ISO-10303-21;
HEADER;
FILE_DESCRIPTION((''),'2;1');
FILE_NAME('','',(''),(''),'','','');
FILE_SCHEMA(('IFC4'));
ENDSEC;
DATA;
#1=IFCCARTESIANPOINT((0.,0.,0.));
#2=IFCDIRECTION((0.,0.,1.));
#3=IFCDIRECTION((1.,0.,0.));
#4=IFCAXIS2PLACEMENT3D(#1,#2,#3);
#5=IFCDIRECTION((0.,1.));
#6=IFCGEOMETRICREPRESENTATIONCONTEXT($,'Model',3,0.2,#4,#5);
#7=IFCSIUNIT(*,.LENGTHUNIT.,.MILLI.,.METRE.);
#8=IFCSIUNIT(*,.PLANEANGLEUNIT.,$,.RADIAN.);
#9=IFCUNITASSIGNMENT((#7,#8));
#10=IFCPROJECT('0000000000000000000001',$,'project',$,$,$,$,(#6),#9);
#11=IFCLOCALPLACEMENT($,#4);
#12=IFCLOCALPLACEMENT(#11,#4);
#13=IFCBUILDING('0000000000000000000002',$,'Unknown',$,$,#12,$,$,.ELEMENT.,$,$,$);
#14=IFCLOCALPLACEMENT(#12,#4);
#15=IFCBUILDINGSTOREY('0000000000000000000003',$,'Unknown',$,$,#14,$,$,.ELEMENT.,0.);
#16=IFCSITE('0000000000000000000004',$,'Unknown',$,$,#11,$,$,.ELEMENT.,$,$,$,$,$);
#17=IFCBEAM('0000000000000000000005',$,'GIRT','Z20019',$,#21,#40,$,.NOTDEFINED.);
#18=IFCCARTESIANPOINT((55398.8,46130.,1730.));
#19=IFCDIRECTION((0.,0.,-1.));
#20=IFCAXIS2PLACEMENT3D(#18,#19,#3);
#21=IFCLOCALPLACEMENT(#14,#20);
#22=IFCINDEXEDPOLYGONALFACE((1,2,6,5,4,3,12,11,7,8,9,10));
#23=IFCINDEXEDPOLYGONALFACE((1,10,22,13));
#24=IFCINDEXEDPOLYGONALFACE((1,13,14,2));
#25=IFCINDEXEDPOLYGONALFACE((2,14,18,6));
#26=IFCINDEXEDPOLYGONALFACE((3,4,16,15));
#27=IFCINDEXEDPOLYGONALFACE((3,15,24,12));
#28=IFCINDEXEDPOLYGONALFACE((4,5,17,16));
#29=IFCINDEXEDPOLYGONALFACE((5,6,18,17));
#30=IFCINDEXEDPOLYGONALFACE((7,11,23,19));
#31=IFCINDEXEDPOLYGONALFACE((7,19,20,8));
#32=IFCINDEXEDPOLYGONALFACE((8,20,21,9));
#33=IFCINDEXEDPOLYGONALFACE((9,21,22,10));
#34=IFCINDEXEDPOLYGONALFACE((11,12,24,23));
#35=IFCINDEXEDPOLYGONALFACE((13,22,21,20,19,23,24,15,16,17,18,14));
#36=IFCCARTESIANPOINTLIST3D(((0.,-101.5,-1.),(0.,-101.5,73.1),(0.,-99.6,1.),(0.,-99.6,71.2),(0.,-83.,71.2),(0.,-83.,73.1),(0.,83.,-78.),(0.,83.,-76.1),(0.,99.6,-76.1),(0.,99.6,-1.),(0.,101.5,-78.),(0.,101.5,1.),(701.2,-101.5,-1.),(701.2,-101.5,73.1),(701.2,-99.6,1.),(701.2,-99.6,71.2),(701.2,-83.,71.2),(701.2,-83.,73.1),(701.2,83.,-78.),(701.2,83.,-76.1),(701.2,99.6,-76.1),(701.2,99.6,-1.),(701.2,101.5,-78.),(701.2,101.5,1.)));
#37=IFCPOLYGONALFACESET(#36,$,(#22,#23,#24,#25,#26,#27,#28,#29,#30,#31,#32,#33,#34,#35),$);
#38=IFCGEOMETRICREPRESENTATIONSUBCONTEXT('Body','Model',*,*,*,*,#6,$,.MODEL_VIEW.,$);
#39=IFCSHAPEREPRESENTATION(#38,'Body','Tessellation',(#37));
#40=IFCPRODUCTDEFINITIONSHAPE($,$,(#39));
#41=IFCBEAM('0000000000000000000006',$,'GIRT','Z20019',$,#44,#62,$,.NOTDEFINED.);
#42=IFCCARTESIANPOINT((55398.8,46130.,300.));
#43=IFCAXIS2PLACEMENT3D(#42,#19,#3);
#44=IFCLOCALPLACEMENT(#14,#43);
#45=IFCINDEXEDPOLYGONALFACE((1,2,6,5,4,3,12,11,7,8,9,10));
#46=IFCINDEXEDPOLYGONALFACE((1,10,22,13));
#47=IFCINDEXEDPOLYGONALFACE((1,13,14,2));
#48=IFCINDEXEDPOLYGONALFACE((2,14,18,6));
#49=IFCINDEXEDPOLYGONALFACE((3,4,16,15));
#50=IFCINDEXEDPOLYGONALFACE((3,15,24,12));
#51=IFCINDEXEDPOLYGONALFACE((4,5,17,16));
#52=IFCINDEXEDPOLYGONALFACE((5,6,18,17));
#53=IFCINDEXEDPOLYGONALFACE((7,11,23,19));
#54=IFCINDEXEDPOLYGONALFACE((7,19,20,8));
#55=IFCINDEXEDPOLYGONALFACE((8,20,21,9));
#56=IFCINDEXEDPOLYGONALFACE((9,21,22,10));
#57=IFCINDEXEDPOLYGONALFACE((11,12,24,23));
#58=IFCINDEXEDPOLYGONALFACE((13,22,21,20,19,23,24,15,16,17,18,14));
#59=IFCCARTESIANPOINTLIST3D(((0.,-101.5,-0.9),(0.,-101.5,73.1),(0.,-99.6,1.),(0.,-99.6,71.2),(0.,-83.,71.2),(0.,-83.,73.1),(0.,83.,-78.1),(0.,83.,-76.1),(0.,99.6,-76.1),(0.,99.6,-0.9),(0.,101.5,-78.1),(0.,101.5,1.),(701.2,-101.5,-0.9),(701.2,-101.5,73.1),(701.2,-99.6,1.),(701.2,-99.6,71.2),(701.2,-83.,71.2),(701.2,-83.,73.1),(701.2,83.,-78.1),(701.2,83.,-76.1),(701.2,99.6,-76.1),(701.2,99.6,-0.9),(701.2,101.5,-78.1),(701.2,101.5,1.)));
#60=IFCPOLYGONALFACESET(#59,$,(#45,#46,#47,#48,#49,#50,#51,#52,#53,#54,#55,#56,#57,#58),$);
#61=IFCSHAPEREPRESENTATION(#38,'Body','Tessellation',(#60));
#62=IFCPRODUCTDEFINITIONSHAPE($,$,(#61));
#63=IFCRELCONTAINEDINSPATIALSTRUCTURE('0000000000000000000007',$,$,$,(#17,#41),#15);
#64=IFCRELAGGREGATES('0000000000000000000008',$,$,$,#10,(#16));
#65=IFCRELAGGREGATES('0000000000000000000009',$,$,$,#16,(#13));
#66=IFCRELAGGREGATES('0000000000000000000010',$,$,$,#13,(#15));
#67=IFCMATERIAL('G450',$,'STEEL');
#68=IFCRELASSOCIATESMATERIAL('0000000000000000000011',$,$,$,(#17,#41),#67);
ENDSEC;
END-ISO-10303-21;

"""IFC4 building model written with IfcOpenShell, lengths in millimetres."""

from ifc_helpers import new_model, si_unit, direction, frame, origin_with_axes, place, context, subcontext, project, spatial, line, indexed_curve, outline, extrude, material, element, save


model = new_model("IFC4")

# Units and contexts
model_context = context("Model", 3, precision=0.2, world=origin_with_axes(), true_north=direction((0.0, 1.0)))
body_context = subcontext(model_context, "Body", "Model", "MODEL_VIEW")
ifc_project = project(units=[si_unit("LENGTHUNIT", "METRE", prefix="MILLI"), si_unit("PLANEANGLEUNIT", "RADIAN")], contexts=[model_context])

# Site, building, storey
site_placement = place(None, origin_with_axes())
site = spatial("IfcSite", under=ifc_project, at=site_placement, Name="Unknown", CompositionType="ELEMENT")
building_placement = place(site_placement, origin_with_axes())
building = spatial("IfcBuilding", under=site, at=building_placement, Name="Unknown", CompositionType="ELEMENT")
storey_placement = place(building_placement, origin_with_axes())
storey = spatial("IfcBuildingStorey", under=building, at=storey_placement, Name="Unknown", CompositionType="ELEMENT", Elevation=0.0)

# Shared definitions
ifc_material_1 = material(Name="G450", Category="STEEL")

# Beams
for number, where, z_axis, x_axis, name in (
    (1, (55398.8, 46130.0, 1730.0), (0.0, 0.0, -1.0), (1.0, 0.0, 0.0), "GIRT"),
    (2, (55398.8, 46130.0, 300.0), (0.0, 0.0, -1.0), (1.0, 0.0, 0.0), "GIRT"),
):
    element("IfcBeam", number, at=place(storey_placement, frame(where, z_axis=z_axis, x_axis=x_axis)), inside=storey, material=ifc_material_1, Name=name, Description="Z20019", PredefinedType="NOTDEFINED", context=body_context, shape_type="SolidModel", body=[
        extrude(outline(indexed_curve([(73.0, -101.5), (73.0, -83.0), (71.2, -83.0), (71.2, -99.6), (0.9, -99.6), (0.9, 101.5), (-78.0, 101.5), (-78.0, 83.0), (-76.2, 83.0), (-76.2, 99.6), (-0.9, 99.6), (-0.9, -101.5)], segments=[line(1, 2, 3, 4, 5, 6, 7, 8, 9, 10, 11, 12, 1)])), frame((0.0, 0.0, 0.0), z_axis=(-1.0, 0.0, 0.0), x_axis=(0.0, 0.0, 1.0)), (0.0, 0.0, -1.0), 701.2),
    ])

save(model, "model.ifc")
